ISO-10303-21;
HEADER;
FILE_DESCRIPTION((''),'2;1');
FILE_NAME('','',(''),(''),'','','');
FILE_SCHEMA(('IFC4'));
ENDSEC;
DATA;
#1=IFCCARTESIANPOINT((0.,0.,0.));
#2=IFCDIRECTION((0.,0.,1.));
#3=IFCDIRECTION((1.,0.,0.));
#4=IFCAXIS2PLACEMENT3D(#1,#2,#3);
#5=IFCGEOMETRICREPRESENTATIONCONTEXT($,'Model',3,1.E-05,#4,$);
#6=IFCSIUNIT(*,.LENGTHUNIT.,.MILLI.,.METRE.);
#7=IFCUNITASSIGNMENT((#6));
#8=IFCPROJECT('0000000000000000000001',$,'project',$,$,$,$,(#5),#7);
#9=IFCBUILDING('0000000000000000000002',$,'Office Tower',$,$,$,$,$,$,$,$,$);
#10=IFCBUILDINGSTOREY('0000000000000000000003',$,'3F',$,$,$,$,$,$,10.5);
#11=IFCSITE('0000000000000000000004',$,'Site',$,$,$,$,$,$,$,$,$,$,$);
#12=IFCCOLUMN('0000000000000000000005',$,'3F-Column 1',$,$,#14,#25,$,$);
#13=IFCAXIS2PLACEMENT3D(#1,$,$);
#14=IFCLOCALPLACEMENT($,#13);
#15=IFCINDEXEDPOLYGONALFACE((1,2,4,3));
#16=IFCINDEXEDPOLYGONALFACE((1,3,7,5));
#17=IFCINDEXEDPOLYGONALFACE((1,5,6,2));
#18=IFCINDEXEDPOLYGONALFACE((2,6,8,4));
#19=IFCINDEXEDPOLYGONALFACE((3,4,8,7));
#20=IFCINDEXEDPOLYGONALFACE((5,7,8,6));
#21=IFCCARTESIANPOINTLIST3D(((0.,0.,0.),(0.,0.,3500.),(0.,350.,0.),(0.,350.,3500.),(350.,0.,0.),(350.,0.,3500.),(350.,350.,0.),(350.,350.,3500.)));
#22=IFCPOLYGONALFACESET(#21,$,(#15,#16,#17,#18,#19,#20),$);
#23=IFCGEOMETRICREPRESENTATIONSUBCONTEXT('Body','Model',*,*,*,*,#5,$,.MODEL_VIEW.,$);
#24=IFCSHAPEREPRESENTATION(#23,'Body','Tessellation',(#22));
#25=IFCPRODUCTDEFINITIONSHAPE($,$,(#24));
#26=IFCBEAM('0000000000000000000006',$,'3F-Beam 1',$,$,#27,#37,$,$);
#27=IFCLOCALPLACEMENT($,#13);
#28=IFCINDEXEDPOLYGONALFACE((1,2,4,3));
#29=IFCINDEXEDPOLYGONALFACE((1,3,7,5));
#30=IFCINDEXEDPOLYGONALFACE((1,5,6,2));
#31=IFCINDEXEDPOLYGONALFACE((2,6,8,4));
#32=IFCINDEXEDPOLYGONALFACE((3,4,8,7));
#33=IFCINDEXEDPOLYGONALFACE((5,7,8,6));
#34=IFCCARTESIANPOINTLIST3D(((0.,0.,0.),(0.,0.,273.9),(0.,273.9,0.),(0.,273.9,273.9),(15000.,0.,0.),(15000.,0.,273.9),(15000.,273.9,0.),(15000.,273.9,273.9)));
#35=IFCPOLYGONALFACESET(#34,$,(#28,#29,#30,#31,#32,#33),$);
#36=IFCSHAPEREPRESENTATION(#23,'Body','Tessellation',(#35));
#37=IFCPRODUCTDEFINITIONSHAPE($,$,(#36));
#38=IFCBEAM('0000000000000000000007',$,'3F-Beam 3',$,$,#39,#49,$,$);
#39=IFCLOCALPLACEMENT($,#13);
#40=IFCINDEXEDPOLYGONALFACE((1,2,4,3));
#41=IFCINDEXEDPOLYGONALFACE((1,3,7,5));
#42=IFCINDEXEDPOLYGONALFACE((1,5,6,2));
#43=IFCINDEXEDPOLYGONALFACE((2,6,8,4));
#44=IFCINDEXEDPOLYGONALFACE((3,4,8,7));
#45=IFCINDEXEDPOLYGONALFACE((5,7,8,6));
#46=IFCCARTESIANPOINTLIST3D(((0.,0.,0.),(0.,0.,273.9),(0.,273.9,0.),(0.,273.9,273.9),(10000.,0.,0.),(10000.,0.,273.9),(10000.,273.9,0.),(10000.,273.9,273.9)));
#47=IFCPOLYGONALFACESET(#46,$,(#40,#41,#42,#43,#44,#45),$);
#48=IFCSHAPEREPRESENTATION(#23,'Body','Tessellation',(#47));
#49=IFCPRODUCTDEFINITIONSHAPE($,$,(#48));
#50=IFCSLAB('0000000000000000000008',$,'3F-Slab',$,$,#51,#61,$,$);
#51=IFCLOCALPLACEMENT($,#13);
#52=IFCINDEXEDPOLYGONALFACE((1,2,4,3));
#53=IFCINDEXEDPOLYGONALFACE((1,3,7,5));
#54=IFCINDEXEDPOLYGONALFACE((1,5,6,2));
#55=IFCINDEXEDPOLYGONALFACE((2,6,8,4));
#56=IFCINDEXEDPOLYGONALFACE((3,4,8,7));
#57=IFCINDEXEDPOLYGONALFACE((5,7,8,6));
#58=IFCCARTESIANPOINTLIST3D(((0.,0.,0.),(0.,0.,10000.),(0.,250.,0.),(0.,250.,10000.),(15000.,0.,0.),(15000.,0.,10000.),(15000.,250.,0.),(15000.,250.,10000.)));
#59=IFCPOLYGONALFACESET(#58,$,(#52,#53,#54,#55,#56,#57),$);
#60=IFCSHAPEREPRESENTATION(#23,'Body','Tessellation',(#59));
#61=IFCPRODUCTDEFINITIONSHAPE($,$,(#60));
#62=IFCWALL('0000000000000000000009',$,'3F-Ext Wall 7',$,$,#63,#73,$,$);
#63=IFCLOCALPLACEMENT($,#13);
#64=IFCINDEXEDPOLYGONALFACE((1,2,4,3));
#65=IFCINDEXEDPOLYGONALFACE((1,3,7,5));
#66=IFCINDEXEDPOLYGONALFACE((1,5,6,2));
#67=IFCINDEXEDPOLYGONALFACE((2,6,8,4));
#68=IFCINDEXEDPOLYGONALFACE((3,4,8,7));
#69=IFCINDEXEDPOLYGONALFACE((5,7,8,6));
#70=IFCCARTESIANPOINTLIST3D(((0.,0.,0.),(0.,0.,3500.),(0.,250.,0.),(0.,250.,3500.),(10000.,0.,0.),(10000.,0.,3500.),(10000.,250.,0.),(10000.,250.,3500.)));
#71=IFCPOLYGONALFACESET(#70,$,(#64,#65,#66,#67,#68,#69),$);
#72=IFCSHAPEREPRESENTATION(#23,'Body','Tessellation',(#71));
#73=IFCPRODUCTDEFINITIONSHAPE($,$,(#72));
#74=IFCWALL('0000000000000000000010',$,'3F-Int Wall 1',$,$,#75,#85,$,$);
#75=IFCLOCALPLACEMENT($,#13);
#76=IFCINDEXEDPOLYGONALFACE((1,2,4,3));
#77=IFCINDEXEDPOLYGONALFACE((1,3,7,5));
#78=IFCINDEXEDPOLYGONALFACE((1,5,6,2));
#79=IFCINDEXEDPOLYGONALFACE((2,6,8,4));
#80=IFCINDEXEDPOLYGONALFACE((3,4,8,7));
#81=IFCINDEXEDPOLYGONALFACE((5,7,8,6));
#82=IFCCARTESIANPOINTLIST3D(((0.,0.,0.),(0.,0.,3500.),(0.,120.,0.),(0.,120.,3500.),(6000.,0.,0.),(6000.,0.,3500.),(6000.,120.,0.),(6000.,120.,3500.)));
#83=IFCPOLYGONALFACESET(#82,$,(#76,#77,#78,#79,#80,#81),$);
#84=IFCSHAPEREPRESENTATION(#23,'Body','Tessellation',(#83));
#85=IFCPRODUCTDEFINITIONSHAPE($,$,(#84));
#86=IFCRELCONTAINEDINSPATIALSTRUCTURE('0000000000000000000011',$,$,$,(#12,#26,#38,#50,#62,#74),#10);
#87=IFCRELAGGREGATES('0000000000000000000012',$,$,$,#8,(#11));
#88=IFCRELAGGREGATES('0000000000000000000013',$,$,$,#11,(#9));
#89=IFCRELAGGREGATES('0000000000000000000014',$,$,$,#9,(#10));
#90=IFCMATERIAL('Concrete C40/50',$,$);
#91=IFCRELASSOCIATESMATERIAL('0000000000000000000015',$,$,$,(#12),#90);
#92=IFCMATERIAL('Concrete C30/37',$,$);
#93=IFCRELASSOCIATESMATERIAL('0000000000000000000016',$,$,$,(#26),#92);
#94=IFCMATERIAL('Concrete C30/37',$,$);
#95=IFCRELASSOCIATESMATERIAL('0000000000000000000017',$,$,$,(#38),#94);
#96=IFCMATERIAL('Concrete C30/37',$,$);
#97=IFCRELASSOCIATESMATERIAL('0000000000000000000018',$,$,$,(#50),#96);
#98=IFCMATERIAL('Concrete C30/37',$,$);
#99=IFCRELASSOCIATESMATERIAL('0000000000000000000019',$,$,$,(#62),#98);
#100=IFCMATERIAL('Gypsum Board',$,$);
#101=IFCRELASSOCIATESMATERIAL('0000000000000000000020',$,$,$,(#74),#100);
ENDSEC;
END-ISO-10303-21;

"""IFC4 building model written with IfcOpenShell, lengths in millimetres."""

from ifc_helpers import new_model, si_unit, origin_with_axes, context, subcontext, project, spatial, indexed_curve, outline, extrude, material, element, save


model = new_model("IFC4")

# Units and contexts
model_context = context("Model", 3, precision=1e-05, world=origin_with_axes())
body_context = subcontext(model_context, "Body", "Model", "MODEL_VIEW")
ifc_project = project(units=[si_unit("LENGTHUNIT", "METRE", prefix="MILLI")], contexts=[model_context])

# Site, building, storey
site = spatial("IfcSite", under=ifc_project, Name="Site")
building = spatial("IfcBuilding", under=site, Name="Office Tower")
storey = spatial("IfcBuildingStorey", under=building, Name="3F", Elevation=10.5)

# Column
ifc_material_1 = material(Name="Concrete C40/50")
element("IfcColumn", 1, inside=storey, material=ifc_material_1, Name="3F-Column 1", context=body_context, shape_type="SweptSolid", body=[
    extrude(outline(indexed_curve([(0.0, 0.0), (0.0, 350.0), (350.0, 350.0), (350.0, 0.0), (0.0, 0.0)], self_intersect=False)), origin_with_axes(), (0.0, 0.0, 1.0), 3500.0),
])

# Beams
ifc_material_2 = material(Name="Concrete C30/37")
element("IfcBeam", 2, inside=storey, material=ifc_material_2, Name="3F-Beam 1", context=body_context, shape_type="SweptSolid", body=[
    extrude(outline(indexed_curve([(0.0, 0.0), (0.0, 273.9), (15000.0, 273.9), (15000.0, 0.0), (0.0, 0.0)], self_intersect=False)), origin_with_axes(), (0.0, 0.0, 1.0), 273.9),
])
ifc_material_3 = material(Name="Concrete C30/37")
element("IfcBeam", 3, inside=storey, material=ifc_material_3, Name="3F-Beam 3", context=body_context, shape_type="SweptSolid", body=[
    extrude(outline(indexed_curve([(0.0, 0.0), (0.0, 273.9), (10000.0, 273.9), (10000.0, 0.0), (0.0, 0.0)], self_intersect=False)), origin_with_axes(), (0.0, 0.0, 1.0), 273.9),
])

# Slab
ifc_material_4 = material(Name="Concrete C30/37")
element("IfcSlab", 4, inside=storey, material=ifc_material_4, Name="3F-Slab", context=body_context, shape_type="SweptSolid", body=[
    extrude(outline(indexed_curve([(0.0, 0.0), (0.0, 250.0), (15000.0, 250.0), (15000.0, 0.0), (0.0, 0.0)], self_intersect=False)), origin_with_axes(), (0.0, 0.0, 1.0), 10000.0),
])

# Walls
ifc_material_5 = material(Name="Concrete C30/37")
element("IfcWall", 5, inside=storey, material=ifc_material_5, Name="3F-Ext Wall 7", context=body_context, shape_type="SweptSolid", body=[
    extrude(outline(indexed_curve([(0.0, 0.0), (0.0, 250.0), (10000.0, 250.0), (10000.0, 0.0), (0.0, 0.0)], self_intersect=False)), origin_with_axes(), (0.0, 0.0, 1.0), 3500.0),
])
ifc_material_6 = material(Name="Gypsum Board")
element("IfcWall", 6, inside=storey, material=ifc_material_6, Name="3F-Int Wall 1", context=body_context, shape_type="SweptSolid", body=[
    extrude(outline(indexed_curve([(0.0, 0.0), (0.0, 120.0), (6000.0, 120.0), (6000.0, 0.0), (0.0, 0.0)], self_intersect=False)), origin_with_axes(), (0.0, 0.0, 1.0), 3500.0),
])

save(model, "model.ifc")
